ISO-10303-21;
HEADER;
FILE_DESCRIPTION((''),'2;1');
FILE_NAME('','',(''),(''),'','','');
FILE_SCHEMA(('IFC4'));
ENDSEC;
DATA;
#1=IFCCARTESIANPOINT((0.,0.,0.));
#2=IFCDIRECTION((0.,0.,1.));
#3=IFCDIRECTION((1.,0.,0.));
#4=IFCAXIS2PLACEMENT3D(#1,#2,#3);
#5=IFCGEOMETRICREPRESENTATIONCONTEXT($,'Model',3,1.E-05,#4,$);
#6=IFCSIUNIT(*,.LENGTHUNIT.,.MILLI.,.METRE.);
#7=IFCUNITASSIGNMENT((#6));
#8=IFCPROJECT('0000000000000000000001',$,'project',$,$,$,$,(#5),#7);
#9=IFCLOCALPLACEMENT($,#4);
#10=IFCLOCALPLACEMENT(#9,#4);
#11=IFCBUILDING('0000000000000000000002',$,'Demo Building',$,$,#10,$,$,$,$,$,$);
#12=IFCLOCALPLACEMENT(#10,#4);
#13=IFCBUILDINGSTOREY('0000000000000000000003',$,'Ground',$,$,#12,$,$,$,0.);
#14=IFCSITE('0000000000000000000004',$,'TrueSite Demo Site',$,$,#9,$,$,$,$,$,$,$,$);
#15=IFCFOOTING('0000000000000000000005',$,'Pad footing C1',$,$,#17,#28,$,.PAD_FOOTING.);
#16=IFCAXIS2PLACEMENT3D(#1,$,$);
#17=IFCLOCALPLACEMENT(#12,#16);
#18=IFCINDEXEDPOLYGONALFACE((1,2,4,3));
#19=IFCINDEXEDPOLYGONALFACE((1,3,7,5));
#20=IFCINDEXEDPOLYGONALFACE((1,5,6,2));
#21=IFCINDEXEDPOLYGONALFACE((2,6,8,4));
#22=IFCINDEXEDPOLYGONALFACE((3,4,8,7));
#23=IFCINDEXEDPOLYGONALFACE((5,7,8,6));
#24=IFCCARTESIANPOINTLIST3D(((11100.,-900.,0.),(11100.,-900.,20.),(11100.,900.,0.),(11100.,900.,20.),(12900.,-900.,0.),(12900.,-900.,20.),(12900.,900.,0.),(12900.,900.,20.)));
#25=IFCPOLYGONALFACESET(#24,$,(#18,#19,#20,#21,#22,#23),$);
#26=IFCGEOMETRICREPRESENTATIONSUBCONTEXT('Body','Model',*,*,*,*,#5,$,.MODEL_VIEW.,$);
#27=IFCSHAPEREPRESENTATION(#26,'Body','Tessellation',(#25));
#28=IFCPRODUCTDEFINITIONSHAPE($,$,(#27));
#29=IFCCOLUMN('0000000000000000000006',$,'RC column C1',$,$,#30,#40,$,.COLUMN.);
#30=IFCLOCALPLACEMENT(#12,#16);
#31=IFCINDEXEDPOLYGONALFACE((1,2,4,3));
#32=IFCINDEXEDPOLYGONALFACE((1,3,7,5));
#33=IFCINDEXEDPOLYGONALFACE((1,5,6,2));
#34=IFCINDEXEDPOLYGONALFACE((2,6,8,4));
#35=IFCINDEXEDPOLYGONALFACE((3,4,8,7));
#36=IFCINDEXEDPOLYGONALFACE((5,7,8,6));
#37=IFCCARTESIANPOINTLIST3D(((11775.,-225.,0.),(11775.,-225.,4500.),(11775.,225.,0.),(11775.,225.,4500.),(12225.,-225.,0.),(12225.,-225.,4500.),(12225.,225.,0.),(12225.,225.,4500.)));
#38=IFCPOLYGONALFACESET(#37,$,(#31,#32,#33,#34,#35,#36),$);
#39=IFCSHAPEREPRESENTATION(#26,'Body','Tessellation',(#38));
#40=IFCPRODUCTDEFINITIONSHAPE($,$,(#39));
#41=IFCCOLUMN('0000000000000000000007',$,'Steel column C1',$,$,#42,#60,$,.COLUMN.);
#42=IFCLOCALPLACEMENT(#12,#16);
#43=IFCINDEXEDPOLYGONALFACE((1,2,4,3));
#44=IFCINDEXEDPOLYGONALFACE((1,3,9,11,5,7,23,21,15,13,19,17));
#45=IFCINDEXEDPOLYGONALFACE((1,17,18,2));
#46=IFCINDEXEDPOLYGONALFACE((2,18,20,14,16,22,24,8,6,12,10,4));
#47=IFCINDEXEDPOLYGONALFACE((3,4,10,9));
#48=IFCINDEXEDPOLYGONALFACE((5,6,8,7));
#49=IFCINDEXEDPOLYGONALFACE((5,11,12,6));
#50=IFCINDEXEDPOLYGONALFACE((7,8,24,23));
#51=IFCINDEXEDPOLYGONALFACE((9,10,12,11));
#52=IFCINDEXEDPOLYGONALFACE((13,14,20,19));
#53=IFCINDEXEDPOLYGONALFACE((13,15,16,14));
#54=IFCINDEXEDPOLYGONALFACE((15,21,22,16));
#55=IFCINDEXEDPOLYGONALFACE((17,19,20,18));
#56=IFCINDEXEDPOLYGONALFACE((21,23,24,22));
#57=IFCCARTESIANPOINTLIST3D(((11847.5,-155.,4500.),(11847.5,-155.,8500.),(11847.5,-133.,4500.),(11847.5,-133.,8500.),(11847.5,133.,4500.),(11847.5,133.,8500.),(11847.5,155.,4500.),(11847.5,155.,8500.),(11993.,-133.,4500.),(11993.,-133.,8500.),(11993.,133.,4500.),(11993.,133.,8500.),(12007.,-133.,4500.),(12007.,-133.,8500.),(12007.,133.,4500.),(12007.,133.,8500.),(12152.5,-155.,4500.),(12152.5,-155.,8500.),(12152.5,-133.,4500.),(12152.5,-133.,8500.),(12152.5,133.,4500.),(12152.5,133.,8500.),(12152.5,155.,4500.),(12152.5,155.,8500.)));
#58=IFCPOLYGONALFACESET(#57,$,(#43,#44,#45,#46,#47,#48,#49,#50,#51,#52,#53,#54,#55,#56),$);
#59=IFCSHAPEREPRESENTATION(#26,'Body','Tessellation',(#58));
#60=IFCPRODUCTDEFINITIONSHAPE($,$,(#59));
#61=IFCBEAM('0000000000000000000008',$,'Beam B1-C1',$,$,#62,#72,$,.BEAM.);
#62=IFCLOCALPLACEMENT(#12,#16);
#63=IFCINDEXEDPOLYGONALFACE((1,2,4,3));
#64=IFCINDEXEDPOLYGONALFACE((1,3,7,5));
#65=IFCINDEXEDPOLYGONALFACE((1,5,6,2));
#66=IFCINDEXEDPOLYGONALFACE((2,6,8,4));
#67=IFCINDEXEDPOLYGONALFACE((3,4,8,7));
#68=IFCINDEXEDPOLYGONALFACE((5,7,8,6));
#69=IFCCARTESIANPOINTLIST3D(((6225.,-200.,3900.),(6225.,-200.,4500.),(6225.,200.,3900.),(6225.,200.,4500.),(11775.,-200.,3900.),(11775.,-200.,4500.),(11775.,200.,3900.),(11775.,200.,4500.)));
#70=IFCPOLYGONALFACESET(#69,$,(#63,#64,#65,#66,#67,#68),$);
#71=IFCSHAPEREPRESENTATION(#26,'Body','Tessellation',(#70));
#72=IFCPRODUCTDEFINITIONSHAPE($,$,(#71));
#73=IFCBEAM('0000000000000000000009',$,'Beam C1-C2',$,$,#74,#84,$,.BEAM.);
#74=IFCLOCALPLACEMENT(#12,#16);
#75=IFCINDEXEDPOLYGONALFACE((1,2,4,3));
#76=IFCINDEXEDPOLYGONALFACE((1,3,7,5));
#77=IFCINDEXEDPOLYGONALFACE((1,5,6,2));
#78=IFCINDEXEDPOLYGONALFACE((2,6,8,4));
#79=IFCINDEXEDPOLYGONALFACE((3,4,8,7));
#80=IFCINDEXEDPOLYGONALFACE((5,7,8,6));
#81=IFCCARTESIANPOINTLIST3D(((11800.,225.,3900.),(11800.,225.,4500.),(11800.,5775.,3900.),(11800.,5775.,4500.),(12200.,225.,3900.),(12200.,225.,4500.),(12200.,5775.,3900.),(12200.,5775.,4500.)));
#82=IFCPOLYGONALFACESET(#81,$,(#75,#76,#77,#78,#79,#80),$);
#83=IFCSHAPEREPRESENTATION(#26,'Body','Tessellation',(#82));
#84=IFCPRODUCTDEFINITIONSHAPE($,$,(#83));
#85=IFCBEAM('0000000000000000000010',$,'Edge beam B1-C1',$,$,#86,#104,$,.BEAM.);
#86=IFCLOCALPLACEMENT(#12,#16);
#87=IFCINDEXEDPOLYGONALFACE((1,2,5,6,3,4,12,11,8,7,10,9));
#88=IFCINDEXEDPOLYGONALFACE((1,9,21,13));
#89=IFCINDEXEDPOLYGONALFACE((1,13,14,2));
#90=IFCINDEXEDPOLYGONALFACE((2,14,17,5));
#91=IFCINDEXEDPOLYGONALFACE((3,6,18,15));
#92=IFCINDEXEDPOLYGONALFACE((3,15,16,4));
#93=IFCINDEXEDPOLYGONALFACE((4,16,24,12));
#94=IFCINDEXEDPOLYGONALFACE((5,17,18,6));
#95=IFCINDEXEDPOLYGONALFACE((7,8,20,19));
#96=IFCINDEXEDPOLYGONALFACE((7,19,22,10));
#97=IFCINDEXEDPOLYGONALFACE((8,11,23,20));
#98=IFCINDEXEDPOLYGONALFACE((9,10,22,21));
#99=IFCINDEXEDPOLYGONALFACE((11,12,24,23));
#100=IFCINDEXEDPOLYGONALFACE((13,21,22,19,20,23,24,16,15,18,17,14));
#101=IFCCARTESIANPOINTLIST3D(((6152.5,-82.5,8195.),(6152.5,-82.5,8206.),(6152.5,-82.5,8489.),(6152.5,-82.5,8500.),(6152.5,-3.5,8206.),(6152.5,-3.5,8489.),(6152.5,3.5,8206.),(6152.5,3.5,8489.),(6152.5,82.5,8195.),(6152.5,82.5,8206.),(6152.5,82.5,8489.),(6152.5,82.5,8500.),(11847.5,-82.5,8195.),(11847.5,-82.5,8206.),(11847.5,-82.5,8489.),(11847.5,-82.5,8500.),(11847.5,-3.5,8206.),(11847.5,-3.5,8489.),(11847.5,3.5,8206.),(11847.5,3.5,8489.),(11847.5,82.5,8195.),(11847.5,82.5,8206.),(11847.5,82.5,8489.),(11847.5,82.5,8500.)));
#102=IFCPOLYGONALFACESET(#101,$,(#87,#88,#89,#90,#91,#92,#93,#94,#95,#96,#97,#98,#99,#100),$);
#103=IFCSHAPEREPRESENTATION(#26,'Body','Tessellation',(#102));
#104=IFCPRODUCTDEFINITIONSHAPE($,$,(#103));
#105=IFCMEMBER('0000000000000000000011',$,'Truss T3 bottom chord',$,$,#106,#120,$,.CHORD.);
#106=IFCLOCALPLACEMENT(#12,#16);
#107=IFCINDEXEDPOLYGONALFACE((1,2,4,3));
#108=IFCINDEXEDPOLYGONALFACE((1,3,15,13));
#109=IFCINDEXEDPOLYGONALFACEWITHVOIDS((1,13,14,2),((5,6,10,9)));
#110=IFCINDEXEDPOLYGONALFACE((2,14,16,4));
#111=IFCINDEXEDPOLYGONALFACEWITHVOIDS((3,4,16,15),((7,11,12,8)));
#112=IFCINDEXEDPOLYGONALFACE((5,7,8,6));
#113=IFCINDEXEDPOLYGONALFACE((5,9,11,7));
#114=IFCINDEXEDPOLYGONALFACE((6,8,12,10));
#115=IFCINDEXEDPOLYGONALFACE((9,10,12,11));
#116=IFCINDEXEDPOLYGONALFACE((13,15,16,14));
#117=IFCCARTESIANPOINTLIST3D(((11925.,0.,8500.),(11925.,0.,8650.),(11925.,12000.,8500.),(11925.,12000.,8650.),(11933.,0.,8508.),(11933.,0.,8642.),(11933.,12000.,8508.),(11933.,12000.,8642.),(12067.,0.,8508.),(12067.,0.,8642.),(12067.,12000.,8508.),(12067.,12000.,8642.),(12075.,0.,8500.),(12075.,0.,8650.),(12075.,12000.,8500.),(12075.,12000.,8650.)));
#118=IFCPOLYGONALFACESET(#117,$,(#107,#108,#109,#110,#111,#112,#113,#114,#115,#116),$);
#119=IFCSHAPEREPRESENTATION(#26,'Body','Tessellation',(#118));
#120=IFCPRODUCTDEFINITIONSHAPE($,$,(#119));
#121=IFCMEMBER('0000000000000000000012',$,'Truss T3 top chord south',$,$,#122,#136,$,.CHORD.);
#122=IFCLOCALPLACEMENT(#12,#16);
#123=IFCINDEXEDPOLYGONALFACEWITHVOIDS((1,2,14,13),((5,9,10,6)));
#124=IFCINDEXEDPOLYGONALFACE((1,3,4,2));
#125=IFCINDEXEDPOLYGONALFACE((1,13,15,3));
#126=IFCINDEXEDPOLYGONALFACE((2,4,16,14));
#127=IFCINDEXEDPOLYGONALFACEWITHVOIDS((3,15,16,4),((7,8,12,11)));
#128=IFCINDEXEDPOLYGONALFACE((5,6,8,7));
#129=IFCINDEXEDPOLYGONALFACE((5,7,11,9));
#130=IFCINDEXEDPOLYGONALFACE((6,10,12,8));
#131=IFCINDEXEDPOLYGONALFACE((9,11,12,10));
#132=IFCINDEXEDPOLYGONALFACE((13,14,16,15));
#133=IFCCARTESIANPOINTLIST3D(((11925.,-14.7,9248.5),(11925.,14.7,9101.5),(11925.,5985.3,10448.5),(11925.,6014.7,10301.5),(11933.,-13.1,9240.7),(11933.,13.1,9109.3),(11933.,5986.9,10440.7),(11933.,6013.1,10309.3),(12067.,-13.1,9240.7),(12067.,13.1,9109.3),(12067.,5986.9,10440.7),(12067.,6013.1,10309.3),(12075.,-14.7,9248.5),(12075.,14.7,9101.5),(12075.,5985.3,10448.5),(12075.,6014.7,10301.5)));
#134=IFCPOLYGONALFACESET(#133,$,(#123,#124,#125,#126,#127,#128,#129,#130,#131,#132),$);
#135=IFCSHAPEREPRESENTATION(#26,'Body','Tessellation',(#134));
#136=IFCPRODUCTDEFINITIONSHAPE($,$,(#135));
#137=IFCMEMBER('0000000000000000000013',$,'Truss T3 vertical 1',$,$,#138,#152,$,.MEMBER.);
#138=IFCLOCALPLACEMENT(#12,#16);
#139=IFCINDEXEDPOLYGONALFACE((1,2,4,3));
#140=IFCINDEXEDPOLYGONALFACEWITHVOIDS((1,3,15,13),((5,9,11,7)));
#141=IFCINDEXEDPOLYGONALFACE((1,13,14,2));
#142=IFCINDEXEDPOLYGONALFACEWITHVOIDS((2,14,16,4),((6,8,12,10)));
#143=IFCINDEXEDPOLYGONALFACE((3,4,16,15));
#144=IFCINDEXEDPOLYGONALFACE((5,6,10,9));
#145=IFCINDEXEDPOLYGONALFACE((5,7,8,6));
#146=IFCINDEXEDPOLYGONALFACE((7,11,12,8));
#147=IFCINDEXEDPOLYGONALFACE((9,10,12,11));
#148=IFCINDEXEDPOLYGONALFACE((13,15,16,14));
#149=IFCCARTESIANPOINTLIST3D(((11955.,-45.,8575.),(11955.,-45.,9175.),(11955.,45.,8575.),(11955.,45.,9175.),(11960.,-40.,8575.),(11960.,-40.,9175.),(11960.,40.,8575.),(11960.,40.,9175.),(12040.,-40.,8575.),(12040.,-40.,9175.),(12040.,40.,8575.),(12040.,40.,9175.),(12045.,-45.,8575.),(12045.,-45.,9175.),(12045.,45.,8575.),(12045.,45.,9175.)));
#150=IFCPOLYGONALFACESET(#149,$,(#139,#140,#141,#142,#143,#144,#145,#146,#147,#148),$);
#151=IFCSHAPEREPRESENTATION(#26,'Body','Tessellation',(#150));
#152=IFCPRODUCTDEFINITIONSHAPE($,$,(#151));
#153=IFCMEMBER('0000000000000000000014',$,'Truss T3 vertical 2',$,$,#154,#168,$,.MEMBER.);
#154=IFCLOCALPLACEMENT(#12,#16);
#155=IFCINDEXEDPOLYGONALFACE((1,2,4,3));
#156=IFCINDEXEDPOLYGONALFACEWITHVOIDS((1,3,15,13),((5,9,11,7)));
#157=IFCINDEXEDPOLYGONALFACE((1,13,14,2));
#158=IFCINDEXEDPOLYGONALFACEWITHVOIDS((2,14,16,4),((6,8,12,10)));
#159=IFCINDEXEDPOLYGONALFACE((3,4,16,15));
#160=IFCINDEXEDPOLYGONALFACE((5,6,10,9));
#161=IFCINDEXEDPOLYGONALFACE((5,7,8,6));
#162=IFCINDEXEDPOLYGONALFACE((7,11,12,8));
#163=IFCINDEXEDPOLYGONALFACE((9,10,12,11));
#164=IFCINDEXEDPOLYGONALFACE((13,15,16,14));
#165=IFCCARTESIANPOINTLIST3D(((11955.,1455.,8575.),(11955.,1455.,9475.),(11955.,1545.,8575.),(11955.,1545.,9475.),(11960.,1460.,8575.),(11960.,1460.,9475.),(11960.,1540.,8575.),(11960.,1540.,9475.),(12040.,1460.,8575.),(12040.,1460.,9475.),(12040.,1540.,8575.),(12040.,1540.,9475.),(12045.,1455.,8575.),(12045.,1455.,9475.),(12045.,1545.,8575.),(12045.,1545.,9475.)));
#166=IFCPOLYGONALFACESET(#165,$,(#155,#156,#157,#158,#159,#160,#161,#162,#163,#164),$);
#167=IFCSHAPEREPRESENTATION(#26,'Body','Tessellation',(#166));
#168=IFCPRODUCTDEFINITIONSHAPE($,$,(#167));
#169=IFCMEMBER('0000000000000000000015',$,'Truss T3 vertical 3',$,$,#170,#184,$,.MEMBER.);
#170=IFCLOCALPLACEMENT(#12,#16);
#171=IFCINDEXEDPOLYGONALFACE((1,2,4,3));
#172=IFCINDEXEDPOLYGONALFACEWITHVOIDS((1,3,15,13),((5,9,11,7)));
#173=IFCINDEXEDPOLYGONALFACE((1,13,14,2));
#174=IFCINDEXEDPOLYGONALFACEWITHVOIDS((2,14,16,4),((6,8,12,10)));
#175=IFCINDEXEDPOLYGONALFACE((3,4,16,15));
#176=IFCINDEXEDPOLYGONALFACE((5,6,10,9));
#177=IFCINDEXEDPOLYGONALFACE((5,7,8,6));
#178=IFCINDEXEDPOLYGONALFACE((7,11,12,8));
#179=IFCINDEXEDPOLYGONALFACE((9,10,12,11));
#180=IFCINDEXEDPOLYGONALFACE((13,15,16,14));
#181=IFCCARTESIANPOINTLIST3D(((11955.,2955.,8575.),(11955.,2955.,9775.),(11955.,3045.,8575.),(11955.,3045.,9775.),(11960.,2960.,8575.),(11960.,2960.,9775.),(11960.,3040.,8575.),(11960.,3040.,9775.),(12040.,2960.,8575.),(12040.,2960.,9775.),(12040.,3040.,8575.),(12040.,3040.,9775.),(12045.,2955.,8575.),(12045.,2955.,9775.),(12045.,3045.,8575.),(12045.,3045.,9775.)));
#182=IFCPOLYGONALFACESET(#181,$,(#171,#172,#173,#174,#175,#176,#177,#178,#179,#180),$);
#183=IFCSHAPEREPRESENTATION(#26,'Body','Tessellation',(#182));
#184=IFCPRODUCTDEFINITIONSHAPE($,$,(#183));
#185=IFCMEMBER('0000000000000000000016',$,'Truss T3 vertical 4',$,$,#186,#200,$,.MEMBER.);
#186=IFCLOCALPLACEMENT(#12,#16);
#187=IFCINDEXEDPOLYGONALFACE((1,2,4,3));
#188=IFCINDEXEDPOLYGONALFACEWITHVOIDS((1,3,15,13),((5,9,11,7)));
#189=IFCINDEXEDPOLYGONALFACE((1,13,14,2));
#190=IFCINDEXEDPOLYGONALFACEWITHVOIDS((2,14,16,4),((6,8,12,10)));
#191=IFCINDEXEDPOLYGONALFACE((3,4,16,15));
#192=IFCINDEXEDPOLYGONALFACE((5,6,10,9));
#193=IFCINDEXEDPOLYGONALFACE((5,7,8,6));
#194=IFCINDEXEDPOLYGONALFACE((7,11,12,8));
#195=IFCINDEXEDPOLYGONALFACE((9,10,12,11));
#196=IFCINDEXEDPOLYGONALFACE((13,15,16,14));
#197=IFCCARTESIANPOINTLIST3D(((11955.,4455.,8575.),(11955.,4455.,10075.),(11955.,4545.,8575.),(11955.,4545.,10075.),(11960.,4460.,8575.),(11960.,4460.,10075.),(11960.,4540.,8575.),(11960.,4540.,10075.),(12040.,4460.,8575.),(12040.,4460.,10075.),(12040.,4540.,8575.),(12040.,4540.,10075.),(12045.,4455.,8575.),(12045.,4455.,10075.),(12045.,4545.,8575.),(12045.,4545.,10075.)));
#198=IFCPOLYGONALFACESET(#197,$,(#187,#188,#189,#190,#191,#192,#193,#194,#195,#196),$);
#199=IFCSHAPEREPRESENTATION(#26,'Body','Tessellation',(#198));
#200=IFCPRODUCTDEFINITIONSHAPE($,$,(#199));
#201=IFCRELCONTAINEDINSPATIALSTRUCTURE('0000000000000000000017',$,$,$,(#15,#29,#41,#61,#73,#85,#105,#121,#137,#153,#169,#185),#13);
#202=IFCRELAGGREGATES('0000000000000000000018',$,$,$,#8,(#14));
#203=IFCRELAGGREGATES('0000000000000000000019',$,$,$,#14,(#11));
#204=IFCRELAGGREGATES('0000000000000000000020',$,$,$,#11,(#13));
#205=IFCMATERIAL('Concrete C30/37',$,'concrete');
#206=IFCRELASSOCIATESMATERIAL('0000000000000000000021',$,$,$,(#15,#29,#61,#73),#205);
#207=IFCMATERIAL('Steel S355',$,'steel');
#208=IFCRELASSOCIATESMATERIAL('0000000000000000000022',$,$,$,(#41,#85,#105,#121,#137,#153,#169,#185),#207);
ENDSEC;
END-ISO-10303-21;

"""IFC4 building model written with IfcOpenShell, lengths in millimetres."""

from ifc_helpers import new_model, si_unit, frame, origin_with_axes, place, context, subcontext, project, spatial, rectangle, hollow_rectangle, i_section, extrude, material, element, save


model = new_model("IFC4")

# Units and contexts
model_context = context("Model", 3, precision=1e-05, world=origin_with_axes())
body_context = subcontext(model_context, "Body", "Model", "MODEL_VIEW")
ifc_project = project(units=[si_unit("LENGTHUNIT", "METRE", prefix="MILLI")], contexts=[model_context])

# Site, building, storey
site_placement = place(None, origin_with_axes())
site = spatial("IfcSite", under=ifc_project, at=site_placement, Name="TrueSite Demo Site")
building_placement = place(site_placement, origin_with_axes())
building = spatial("IfcBuilding", under=site, at=building_placement, Name="Demo Building")
storey_placement = place(building_placement, origin_with_axes())
storey = spatial("IfcBuildingStorey", under=building, at=storey_placement, Name="Ground", Elevation=0.0)

# Footing
ifc_material_1 = material(Name="Concrete C30/37", Category="concrete")
footing_placement = place(storey_placement, frame((12000.0, 0.0, 0.0), z_axis=(0.0, 0.0, 1.0), x_axis=(1.0, 0.0, 0.0)))
element("IfcFooting", 1, at=footing_placement, inside=storey, material=ifc_material_1, Name="Pad footing C1", PredefinedType="PAD_FOOTING", context=body_context, shape_type="SweptSolid", body=[
    extrude(rectangle(XDim=1800.0, YDim=1800.0), origin_with_axes(), (0.0, 0.0, 1.0), 20.0),
])

# Columns
column_1_placement = place(storey_placement, frame((12000.0, 0.0, 0.0), z_axis=(0.0, 0.0, 1.0), x_axis=(1.0, 0.0, 0.0)))
element("IfcColumn", 2, at=column_1_placement, inside=storey, material=ifc_material_1, Name="RC column C1", PredefinedType="COLUMN", context=body_context, shape_type="SweptSolid", body=[
    extrude(rectangle(XDim=450.0, YDim=450.0), origin_with_axes(), (0.0, 0.0, 1.0), 4500.0),
])
ifc_material_2 = material(Name="Steel S355", Category="steel")
column_2_placement = place(storey_placement, frame((12000.0, 0.0, 4500.0), z_axis=(0.0, 0.0, 1.0), x_axis=(1.0, 0.0, 0.0)))
element("IfcColumn", 3, at=column_2_placement, inside=storey, material=ifc_material_2, Name="Steel column C1", PredefinedType="COLUMN", context=body_context, shape_type="SweptSolid", body=[
    extrude(i_section(OverallWidth=305.0, OverallDepth=310.0, WebThickness=14.0, FlangeThickness=22.0), origin_with_axes(), (0.0, 0.0, 1.0), 4000.0),
])

# Beams
for number, where, z_axis, x_axis, name in (
    (4, (6225.0, 0.0, 4200.0), (1.0, 0.0, 0.0), (0.0, 1.0, 0.0), "Beam B1-C1"),
    (5, (12000.0, 225.0, 4200.0), (0.0, 1.0, 0.0), (-1.0, 0.0, 0.0), "Beam C1-C2"),
):
    element("IfcBeam", number, at=place(storey_placement, frame(where, z_axis=z_axis, x_axis=x_axis)), inside=storey, material=ifc_material_1, Name=name, PredefinedType="BEAM", context=body_context, shape_type="SweptSolid", body=[
        extrude(rectangle(XDim=400.0, YDim=600.0), origin_with_axes(), (0.0, 0.0, 1.0), 5550.0),
    ])
beam_placement = place(storey_placement, frame((6152.5, 0.0, 8347.5), z_axis=(1.0, 0.0, 0.0), x_axis=(0.0, 1.0, 0.0)))
element("IfcBeam", 6, at=beam_placement, inside=storey, material=ifc_material_2, Name="Edge beam B1-C1", PredefinedType="BEAM", context=body_context, shape_type="SweptSolid", body=[
    extrude(i_section(OverallWidth=165.0, OverallDepth=305.0, WebThickness=7.0, FlangeThickness=11.0), origin_with_axes(), (0.0, 0.0, 1.0), 5695.0),
])

# Members
member_1_placement = place(storey_placement, frame((12000.0, 0.0, 8575.0), z_axis=(0.0, 1.0, 0.0), x_axis=(-1.0, 0.0, 0.0)))
element("IfcMember", 7, at=member_1_placement, inside=storey, material=ifc_material_2, Name="Truss T3 bottom chord", PredefinedType="CHORD", context=body_context, shape_type="SweptSolid", body=[
    extrude(hollow_rectangle(XDim=150.0, YDim=150.0, WallThickness=8.0), origin_with_axes(), (0.0, 0.0, 1.0), 12000.0),
])
member_2_placement = place(storey_placement, frame((12000.0, 0.0, 9175.0), z_axis=(0.0, 0.980581, 0.196116), x_axis=(-1.0, 0.0, 0.0)))
element("IfcMember", 8, at=member_2_placement, inside=storey, material=ifc_material_2, Name="Truss T3 top chord south", PredefinedType="CHORD", context=body_context, shape_type="SweptSolid", body=[
    extrude(hollow_rectangle(XDim=150.0, YDim=150.0, WallThickness=8.0), origin_with_axes(), (0.0, 0.0, 1.0), 6118.8),
])
member_3_placement = place(storey_placement, frame((12000.0, 0.0, 8575.0), z_axis=(0.0, 0.0, 1.0), x_axis=(1.0, 0.0, 0.0)))
element("IfcMember", 9, at=member_3_placement, inside=storey, material=ifc_material_2, Name="Truss T3 vertical 1", PredefinedType="MEMBER", context=body_context, shape_type="SweptSolid", body=[
    extrude(hollow_rectangle(XDim=90.0, YDim=90.0, WallThickness=5.0), origin_with_axes(), (0.0, 0.0, 1.0), 600.0),
])
member_4_placement = place(storey_placement, frame((12000.0, 1500.0, 8575.0), z_axis=(0.0, 0.0, 1.0), x_axis=(1.0, 0.0, 0.0)))
element("IfcMember", 10, at=member_4_placement, inside=storey, material=ifc_material_2, Name="Truss T3 vertical 2", PredefinedType="MEMBER", context=body_context, shape_type="SweptSolid", body=[
    extrude(hollow_rectangle(XDim=90.0, YDim=90.0, WallThickness=5.0), origin_with_axes(), (0.0, 0.0, 1.0), 900.0),
])
member_5_placement = place(storey_placement, frame((12000.0, 3000.0, 8575.0), z_axis=(0.0, 0.0, 1.0), x_axis=(1.0, 0.0, 0.0)))
element("IfcMember", 11, at=member_5_placement, inside=storey, material=ifc_material_2, Name="Truss T3 vertical 3", PredefinedType="MEMBER", context=body_context, shape_type="SweptSolid", body=[
    extrude(hollow_rectangle(XDim=90.0, YDim=90.0, WallThickness=5.0), origin_with_axes(), (0.0, 0.0, 1.0), 1200.0),
])
member_6_placement = place(storey_placement, frame((12000.0, 4500.0, 8575.0), z_axis=(0.0, 0.0, 1.0), x_axis=(1.0, 0.0, 0.0)))
element("IfcMember", 12, at=member_6_placement, inside=storey, material=ifc_material_2, Name="Truss T3 vertical 4", PredefinedType="MEMBER", context=body_context, shape_type="SweptSolid", body=[
    extrude(hollow_rectangle(XDim=90.0, YDim=90.0, WallThickness=5.0), origin_with_axes(), (0.0, 0.0, 1.0), 1500.0),
])

save(model, "model.ifc")
